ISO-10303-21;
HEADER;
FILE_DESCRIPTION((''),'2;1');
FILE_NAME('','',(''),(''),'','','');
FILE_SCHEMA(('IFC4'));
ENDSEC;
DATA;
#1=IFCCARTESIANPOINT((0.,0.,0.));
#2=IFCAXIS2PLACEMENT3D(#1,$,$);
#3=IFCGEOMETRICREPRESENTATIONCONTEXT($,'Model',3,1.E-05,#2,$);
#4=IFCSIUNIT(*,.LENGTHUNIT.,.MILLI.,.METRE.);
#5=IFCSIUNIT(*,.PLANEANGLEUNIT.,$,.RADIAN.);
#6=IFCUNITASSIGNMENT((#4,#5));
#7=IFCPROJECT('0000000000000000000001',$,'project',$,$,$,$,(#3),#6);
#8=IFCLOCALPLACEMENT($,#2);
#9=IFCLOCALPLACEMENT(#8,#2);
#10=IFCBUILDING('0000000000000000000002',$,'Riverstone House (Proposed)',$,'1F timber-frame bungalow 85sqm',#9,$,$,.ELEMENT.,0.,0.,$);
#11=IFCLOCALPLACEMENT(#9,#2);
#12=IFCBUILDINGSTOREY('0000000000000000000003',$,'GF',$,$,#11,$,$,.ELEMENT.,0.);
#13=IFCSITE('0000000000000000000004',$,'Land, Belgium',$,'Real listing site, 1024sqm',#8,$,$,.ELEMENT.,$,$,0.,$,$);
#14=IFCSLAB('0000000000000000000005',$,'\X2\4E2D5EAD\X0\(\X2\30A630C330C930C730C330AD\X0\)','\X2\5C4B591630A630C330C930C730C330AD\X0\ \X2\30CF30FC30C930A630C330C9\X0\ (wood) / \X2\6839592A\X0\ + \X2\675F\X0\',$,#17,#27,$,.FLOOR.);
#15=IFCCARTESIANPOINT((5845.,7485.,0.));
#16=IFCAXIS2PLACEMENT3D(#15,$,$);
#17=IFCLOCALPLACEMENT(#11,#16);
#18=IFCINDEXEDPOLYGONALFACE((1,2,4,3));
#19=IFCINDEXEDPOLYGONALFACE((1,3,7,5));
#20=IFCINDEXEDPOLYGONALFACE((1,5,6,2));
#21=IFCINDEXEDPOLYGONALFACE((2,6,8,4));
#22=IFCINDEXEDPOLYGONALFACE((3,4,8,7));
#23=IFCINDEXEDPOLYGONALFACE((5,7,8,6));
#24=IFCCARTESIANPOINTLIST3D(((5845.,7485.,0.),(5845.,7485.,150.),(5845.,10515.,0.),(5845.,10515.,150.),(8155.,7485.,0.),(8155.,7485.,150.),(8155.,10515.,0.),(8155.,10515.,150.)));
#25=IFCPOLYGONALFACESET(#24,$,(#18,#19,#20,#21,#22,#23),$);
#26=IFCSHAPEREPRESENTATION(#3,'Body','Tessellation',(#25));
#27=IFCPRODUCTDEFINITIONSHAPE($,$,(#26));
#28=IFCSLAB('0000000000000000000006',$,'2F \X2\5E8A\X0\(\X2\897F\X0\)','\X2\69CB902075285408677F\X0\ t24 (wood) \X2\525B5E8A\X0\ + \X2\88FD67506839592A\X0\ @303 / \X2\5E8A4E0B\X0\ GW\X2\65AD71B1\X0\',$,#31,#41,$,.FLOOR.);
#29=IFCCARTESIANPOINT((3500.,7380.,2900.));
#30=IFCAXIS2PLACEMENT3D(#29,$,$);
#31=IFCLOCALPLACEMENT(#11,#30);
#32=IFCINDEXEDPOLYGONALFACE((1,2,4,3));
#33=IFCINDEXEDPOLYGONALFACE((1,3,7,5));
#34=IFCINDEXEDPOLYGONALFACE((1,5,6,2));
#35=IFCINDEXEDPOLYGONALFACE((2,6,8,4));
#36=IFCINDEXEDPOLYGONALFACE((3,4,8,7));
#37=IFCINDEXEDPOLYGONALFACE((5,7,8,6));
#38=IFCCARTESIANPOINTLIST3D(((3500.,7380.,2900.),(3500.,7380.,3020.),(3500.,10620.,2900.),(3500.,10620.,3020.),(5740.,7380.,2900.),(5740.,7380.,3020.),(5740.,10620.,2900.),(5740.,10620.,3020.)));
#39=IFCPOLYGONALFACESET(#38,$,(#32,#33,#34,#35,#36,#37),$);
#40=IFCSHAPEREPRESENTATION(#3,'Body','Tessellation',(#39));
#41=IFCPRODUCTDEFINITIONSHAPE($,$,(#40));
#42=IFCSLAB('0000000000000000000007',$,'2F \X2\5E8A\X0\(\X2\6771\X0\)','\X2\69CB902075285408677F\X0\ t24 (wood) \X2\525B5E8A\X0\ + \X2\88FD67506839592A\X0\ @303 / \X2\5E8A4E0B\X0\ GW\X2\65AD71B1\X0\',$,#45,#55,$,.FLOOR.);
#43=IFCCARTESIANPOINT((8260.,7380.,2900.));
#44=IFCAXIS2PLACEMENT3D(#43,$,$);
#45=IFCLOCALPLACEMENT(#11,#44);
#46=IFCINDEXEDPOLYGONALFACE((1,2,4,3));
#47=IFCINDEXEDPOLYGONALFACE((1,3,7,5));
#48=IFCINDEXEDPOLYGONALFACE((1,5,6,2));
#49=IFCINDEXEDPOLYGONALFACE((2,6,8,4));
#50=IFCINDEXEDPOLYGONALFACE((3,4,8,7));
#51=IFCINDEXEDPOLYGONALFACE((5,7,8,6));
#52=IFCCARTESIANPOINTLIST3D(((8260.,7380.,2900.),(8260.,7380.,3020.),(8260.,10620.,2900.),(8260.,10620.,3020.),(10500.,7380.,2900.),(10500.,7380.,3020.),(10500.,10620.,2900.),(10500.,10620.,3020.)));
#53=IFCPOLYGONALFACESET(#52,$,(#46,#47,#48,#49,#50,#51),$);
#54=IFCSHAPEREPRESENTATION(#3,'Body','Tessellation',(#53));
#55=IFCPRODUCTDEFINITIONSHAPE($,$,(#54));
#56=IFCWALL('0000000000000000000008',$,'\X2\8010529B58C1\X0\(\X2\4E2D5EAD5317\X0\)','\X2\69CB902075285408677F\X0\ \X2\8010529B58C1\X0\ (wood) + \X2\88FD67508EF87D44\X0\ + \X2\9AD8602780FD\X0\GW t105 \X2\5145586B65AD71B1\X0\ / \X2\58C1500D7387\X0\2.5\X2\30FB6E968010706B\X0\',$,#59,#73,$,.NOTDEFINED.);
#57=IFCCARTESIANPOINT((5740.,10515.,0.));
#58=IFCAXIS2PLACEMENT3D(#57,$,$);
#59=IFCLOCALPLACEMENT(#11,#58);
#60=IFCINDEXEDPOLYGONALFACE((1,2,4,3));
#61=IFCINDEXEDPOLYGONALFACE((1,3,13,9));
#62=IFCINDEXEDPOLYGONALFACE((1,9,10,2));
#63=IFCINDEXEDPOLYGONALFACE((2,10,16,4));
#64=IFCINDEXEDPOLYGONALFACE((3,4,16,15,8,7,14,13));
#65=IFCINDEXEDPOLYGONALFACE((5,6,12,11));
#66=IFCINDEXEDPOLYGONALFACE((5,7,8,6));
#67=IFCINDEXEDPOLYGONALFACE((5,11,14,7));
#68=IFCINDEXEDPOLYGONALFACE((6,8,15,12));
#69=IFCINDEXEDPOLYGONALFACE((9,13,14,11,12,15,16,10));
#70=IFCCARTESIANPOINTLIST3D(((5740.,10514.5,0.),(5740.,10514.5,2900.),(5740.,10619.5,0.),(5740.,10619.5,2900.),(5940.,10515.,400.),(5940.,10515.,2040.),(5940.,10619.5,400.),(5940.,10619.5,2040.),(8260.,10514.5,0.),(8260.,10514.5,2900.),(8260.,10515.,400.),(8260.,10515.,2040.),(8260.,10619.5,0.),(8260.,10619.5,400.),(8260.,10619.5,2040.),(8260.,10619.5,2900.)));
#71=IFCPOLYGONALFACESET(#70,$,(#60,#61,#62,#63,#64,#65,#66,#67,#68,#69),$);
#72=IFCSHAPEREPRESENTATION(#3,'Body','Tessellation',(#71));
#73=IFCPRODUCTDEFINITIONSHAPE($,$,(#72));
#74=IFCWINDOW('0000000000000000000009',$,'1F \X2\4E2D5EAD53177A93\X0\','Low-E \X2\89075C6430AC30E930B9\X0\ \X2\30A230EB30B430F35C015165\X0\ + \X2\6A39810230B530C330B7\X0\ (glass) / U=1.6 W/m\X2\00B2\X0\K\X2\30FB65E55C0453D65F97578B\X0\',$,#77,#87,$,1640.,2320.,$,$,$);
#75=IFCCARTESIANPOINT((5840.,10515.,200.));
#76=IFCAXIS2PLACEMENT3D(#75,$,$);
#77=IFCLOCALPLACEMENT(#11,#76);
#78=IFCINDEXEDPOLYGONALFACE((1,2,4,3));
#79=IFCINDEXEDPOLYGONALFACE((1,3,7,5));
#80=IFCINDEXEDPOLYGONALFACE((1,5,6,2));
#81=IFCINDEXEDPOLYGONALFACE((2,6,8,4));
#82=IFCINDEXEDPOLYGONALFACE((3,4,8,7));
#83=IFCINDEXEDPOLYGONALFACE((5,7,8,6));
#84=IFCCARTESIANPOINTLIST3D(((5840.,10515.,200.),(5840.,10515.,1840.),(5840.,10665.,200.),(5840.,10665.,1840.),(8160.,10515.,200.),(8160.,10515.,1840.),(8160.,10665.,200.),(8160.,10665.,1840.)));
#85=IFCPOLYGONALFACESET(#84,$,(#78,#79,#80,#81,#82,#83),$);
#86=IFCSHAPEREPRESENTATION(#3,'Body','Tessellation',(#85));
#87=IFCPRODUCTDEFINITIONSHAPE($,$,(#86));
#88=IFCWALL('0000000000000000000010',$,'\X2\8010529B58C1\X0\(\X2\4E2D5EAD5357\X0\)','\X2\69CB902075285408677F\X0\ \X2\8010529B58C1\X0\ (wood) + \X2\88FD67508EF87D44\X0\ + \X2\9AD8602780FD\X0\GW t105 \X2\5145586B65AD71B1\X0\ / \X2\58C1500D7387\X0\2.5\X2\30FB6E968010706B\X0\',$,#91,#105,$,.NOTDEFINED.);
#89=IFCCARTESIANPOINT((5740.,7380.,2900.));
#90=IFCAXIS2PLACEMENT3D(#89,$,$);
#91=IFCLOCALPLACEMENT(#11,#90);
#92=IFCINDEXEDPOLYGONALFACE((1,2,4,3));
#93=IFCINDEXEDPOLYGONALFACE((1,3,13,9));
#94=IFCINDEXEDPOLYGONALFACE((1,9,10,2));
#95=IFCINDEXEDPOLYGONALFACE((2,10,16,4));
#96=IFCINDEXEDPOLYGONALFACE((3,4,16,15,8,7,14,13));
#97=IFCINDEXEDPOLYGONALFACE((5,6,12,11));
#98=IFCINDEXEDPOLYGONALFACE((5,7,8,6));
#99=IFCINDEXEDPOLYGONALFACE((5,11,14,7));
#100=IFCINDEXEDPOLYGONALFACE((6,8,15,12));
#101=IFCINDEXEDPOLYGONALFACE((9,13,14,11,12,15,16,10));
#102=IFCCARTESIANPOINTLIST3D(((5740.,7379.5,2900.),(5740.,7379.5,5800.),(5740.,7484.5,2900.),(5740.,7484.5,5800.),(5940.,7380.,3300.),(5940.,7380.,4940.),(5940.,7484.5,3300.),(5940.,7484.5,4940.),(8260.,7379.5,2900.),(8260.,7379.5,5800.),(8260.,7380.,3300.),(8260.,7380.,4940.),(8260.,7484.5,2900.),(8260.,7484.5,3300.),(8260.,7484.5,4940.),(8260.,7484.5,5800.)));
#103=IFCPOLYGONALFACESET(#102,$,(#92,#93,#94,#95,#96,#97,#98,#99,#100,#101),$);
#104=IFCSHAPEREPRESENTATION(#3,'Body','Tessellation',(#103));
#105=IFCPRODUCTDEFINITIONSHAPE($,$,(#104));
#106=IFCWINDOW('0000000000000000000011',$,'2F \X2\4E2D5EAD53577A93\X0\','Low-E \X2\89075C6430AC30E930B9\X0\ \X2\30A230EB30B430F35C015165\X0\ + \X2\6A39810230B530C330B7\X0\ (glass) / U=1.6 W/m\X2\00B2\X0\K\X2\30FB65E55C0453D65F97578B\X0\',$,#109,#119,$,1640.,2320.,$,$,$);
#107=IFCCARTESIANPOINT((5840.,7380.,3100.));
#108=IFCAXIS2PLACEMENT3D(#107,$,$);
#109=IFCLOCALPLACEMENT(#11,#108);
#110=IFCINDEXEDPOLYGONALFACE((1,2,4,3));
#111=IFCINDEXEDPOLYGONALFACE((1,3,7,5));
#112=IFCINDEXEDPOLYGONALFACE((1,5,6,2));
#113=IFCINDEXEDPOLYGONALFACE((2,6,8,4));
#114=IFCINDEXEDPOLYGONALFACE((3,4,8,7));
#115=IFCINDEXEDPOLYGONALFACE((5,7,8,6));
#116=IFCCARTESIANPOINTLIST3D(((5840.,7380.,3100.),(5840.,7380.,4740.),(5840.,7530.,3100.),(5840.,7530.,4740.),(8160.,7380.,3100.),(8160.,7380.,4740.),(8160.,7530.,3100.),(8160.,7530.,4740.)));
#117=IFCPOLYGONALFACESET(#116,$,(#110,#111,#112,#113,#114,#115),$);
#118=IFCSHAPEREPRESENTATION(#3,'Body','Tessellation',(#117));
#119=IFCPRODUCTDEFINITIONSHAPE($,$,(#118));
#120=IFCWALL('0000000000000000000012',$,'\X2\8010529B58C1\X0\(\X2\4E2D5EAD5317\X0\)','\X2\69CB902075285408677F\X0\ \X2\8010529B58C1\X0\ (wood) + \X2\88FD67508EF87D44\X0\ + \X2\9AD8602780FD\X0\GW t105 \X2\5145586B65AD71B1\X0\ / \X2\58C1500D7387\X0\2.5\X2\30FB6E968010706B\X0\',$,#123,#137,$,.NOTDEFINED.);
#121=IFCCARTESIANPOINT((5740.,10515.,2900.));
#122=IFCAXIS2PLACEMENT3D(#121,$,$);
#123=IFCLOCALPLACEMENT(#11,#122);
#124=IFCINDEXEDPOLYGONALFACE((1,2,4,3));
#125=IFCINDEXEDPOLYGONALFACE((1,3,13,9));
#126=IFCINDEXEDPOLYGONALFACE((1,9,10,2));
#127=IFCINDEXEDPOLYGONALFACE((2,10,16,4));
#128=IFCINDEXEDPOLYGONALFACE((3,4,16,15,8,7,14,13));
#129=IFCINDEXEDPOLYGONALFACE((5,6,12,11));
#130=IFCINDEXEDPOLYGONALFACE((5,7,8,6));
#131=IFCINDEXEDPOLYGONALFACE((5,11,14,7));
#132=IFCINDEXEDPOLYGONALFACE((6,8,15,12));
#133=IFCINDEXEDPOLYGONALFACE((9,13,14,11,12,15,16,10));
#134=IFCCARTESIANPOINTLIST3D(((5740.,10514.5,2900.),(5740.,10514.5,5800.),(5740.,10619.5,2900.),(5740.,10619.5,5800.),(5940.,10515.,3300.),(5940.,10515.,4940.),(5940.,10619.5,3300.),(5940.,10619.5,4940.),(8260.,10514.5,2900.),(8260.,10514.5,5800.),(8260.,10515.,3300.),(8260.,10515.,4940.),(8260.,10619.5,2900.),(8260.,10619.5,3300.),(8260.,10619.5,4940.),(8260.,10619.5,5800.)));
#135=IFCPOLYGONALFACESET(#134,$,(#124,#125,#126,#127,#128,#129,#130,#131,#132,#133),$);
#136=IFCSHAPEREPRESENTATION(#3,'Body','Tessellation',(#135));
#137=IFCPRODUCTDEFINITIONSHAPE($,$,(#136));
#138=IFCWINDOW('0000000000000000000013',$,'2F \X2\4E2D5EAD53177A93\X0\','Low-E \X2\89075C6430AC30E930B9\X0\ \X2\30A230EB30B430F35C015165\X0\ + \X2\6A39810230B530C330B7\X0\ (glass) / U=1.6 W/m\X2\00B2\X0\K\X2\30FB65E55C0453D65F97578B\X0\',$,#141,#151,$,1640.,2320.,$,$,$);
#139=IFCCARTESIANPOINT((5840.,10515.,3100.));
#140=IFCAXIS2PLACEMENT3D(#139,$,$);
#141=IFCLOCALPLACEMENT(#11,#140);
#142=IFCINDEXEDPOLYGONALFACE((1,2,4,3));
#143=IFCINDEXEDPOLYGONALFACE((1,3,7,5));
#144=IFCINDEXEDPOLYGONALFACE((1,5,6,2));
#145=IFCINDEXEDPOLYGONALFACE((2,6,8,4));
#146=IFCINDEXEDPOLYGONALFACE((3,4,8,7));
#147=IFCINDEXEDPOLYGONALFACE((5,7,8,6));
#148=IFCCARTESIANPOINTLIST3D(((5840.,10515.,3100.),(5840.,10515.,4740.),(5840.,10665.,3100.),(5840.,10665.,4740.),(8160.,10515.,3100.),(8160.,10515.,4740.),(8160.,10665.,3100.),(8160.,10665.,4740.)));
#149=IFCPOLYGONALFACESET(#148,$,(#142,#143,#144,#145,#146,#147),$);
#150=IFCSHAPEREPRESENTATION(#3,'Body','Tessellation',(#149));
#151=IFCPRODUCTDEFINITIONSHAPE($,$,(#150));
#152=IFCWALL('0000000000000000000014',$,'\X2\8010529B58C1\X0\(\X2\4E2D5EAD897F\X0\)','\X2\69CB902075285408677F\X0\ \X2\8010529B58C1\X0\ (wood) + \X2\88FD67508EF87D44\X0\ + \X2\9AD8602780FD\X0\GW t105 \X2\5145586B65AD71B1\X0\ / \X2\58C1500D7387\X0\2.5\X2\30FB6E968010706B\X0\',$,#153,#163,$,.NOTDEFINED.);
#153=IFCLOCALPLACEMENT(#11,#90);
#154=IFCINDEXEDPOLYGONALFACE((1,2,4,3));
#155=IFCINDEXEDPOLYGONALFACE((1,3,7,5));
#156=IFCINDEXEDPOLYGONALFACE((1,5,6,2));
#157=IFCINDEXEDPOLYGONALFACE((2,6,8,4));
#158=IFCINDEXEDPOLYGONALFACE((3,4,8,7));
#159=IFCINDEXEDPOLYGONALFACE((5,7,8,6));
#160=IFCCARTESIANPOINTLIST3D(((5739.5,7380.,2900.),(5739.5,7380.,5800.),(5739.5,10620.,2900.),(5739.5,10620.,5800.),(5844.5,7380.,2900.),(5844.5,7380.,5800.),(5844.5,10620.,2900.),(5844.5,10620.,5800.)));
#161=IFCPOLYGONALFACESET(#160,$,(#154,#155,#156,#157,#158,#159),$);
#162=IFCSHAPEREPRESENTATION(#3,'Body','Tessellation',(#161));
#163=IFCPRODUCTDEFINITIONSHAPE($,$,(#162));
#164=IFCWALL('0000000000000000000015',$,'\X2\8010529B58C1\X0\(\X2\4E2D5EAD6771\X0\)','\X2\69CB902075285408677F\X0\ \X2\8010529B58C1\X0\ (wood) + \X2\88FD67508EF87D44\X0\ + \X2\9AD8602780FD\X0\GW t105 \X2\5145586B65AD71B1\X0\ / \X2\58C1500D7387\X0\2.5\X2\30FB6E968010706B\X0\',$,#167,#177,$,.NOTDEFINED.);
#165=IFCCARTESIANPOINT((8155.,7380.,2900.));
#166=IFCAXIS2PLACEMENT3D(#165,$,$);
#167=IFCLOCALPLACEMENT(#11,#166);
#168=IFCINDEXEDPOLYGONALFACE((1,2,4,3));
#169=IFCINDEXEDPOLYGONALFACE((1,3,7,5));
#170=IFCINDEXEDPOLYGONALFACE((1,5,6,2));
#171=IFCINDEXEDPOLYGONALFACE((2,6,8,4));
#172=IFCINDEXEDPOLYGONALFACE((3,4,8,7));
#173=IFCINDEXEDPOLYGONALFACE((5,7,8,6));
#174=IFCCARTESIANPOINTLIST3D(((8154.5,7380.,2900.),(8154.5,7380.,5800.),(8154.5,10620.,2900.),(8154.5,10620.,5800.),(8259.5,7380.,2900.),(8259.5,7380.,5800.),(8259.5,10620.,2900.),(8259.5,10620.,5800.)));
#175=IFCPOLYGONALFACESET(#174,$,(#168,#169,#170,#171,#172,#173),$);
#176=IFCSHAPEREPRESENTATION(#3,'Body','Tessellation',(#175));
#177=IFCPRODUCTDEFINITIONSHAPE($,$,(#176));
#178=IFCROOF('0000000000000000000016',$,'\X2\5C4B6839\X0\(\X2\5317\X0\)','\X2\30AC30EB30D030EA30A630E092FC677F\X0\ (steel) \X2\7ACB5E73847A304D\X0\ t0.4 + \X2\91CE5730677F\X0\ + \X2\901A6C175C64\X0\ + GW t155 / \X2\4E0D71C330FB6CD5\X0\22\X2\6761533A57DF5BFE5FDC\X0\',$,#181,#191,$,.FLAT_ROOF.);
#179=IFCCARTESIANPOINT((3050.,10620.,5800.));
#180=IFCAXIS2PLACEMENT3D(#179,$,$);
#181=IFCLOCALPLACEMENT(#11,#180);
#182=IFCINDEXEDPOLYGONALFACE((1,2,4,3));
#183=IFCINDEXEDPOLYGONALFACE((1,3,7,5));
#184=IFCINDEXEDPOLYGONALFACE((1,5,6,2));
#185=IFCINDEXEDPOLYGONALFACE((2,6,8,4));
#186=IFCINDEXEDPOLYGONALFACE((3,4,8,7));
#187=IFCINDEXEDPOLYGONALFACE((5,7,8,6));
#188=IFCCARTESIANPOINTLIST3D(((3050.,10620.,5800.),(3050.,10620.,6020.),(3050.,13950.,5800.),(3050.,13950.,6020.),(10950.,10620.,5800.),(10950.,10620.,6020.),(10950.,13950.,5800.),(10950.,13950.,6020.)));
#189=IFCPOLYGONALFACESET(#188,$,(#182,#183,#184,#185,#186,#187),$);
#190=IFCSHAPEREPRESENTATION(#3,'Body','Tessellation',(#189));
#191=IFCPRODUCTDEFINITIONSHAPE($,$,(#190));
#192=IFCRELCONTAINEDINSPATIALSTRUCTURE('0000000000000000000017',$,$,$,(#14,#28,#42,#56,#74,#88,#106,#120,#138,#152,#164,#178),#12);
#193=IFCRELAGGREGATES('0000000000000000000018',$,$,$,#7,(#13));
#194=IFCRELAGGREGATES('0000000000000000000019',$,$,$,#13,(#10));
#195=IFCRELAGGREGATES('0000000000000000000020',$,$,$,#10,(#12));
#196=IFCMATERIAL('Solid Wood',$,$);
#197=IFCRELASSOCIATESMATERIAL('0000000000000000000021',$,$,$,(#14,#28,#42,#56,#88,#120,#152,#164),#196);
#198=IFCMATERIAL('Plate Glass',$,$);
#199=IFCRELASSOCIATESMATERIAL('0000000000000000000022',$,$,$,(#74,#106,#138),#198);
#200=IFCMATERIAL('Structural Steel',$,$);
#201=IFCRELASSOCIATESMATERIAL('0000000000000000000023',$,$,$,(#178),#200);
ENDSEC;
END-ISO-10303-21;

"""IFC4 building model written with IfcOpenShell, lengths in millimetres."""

from ifc_helpers import new_model, si_unit, frame, frame_2d, origin, place, context, project, spatial, rectangle, extrude, material, element, fill, save


model = new_model("IFC4")

# Units and contexts
model_context = context("Model", 3, precision=1e-05, world=origin())
ifc_project = project(units=[si_unit("LENGTHUNIT", "METRE", prefix="MILLI"), si_unit("PLANEANGLEUNIT", "RADIAN")], contexts=[model_context])

# Site, building, storey
site_placement = place(None, origin())
site = spatial("IfcSite", under=ifc_project, at=site_placement, Name="Land, Belgium", ObjectType="Real listing site, 1024sqm", CompositionType="ELEMENT", RefElevation=0.0)
building_placement = place(site_placement, origin())
building = spatial("IfcBuilding", under=site, at=building_placement, Name="Riverstone House (Proposed)", ObjectType="1F timber-frame bungalow 85sqm", CompositionType="ELEMENT", ElevationOfRefHeight=0.0, ElevationOfTerrain=0.0)
storey_placement = place(building_placement, origin())
storey = spatial("IfcBuildingStorey", under=building, at=storey_placement, Name="GF", CompositionType="ELEMENT", Elevation=0.0)

# Slabs
ifc_material_1 = material(Name="Solid Wood")
slab_1_placement = place(storey_placement, frame((5845.0, 7485.0, 0.0)))
element("IfcSlab", 1, at=slab_1_placement, inside=storey, material=ifc_material_1, Name="中庭(ウッドデッキ)", Description="屋外ウッドデッキ ハードウッド (wood) / 根太 + 束", PredefinedType="FLOOR", context=model_context, shape_type="SweptSolid", body=[
    extrude(rectangle(XDim=2310.0, YDim=3030.0, at=frame_2d((1155.0, 1515.0))), frame((5845.0, 7485.0, 0.0)), (0.0, 0.0, 1.0), 150.0),
])
slab_2_placement = place(storey_placement, frame((3500.0, 7380.0, 2900.0)))
element("IfcSlab", 2, at=slab_2_placement, inside=storey, material=ifc_material_1, Name="2F 床(西)", Description="構造用合板 t24 (wood) 剛床 + 製材根太 @303 / 床下 GW断熱", PredefinedType="FLOOR", context=model_context, shape_type="SweptSolid", body=[
    extrude(rectangle(XDim=2240.0, YDim=3240.0, at=frame_2d((1120.0, 1620.0))), frame((3500.0, 7380.0, 2900.0)), (0.0, 0.0, 1.0), 120.0),
])
slab_3_placement = place(storey_placement, frame((8260.0, 7380.0, 2900.0)))
element("IfcSlab", 3, at=slab_3_placement, inside=storey, material=ifc_material_1, Name="2F 床(東)", Description="構造用合板 t24 (wood) 剛床 + 製材根太 @303 / 床下 GW断熱", PredefinedType="FLOOR", context=model_context, shape_type="SweptSolid", body=[
    extrude(rectangle(XDim=2240.0, YDim=3240.0, at=frame_2d((1120.0, 1620.0))), frame((8260.0, 7380.0, 2900.0)), (0.0, 0.0, 1.0), 120.0),
])

# Walls, openings, windows
wall_1_placement = place(storey_placement, frame((5740.0, 10515.0, 0.0)))
wall_1 = element("IfcWall", 4, at=wall_1_placement, inside=storey, material=ifc_material_1, Name="耐力壁(中庭北)", Description="構造用合板 耐力壁 (wood) + 製材軸組 + 高性能GW t105 充填断熱 / 壁倍率2.5・準耐火", PredefinedType="NOTDEFINED", context=model_context, shape_type="SweptSolid", body=[
    extrude(rectangle(XDim=2520.0, YDim=105.0, at=frame_2d((1260.0, 52.0))), frame((5740.0, 10515.0, 0.0)), (0.0, 0.0, 1.0), 2900.0),
])
opening_1_placement = place(storey_placement, frame((5840.0, 10515.0, 200.0)))
opening_1 = element("IfcOpeningElement", 5, at=opening_1_placement, cuts=wall_1, PredefinedType="NOTDEFINED", context=model_context, shape_type="SweptSolid", body=[
    extrude(rectangle(XDim=2320.0, YDim=150.0, at=frame_2d((1160.0, 75.0))), frame((5840.0, 10515.0, 200.0)), (0.0, 0.0, 1.0), 1640.0),
])
ifc_material_2 = material(Name="Plate Glass")
window_1_placement = place(storey_placement, frame((5840.0, 10515.0, 200.0)))
window_1 = element("IfcWindow", 6, at=window_1_placement, inside=storey, material=ifc_material_2, Name="1F 中庭北窓", Description="Low-E 複層ガラス アルゴン封入 + 樹脂サッシ (glass) / U=1.6 W/m²K・日射取得型", OverallHeight=1640.0, OverallWidth=2320.0, context=model_context, shape_type="SweptSolid", body=[
    extrude(rectangle(XDim=2320.0, YDim=150.0, at=frame_2d((1160.0, 75.0))), frame((5840.0, 10515.0, 200.0)), (0.0, 0.0, 1.0), 1640.0),
])
fill(opening_1, window_1)
wall_2_placement = place(storey_placement, frame((5740.0, 7380.0, 2900.0)))
wall_2 = element("IfcWall", 7, at=wall_2_placement, inside=storey, material=ifc_material_1, Name="耐力壁(中庭南)", Description="構造用合板 耐力壁 (wood) + 製材軸組 + 高性能GW t105 充填断熱 / 壁倍率2.5・準耐火", PredefinedType="NOTDEFINED", context=model_context, shape_type="SweptSolid", body=[
    extrude(rectangle(XDim=2520.0, YDim=105.0, at=frame_2d((1260.0, 52.0))), frame((5740.0, 7380.0, 2900.0)), (0.0, 0.0, 1.0), 2900.0),
])
opening_2_placement = place(storey_placement, frame((5840.0, 7380.0, 3100.0)))
opening_2 = element("IfcOpeningElement", 8, at=opening_2_placement, cuts=wall_2, PredefinedType="NOTDEFINED", context=model_context, shape_type="SweptSolid", body=[
    extrude(rectangle(XDim=2320.0, YDim=150.0, at=frame_2d((1160.0, 75.0))), frame((5840.0, 7380.0, 3100.0)), (0.0, 0.0, 1.0), 1640.0),
])
window_2_placement = place(storey_placement, frame((5840.0, 7380.0, 3100.0)))
window_2 = element("IfcWindow", 9, at=window_2_placement, inside=storey, material=ifc_material_2, Name="2F 中庭南窓", Description="Low-E 複層ガラス アルゴン封入 + 樹脂サッシ (glass) / U=1.6 W/m²K・日射取得型", OverallHeight=1640.0, OverallWidth=2320.0, context=model_context, shape_type="SweptSolid", body=[
    extrude(rectangle(XDim=2320.0, YDim=150.0, at=frame_2d((1160.0, 75.0))), frame((5840.0, 7380.0, 3100.0)), (0.0, 0.0, 1.0), 1640.0),
])
fill(opening_2, window_2)
wall_3_placement = place(storey_placement, frame((5740.0, 10515.0, 2900.0)))
wall_3 = element("IfcWall", 10, at=wall_3_placement, inside=storey, material=ifc_material_1, Name="耐力壁(中庭北)", Description="構造用合板 耐力壁 (wood) + 製材軸組 + 高性能GW t105 充填断熱 / 壁倍率2.5・準耐火", PredefinedType="NOTDEFINED", context=model_context, shape_type="SweptSolid", body=[
    extrude(rectangle(XDim=2520.0, YDim=105.0, at=frame_2d((1260.0, 52.0))), frame((5740.0, 10515.0, 2900.0)), (0.0, 0.0, 1.0), 2900.0),
])
opening_3_placement = place(storey_placement, frame((5840.0, 10515.0, 3100.0)))
opening_3 = element("IfcOpeningElement", 11, at=opening_3_placement, cuts=wall_3, PredefinedType="NOTDEFINED", context=model_context, shape_type="SweptSolid", body=[
    extrude(rectangle(XDim=2320.0, YDim=150.0, at=frame_2d((1160.0, 75.0))), frame((5840.0, 10515.0, 3100.0)), (0.0, 0.0, 1.0), 1640.0),
])
window_3_placement = place(storey_placement, frame((5840.0, 10515.0, 3100.0)))
window_3 = element("IfcWindow", 12, at=window_3_placement, inside=storey, material=ifc_material_2, Name="2F 中庭北窓", Description="Low-E 複層ガラス アルゴン封入 + 樹脂サッシ (glass) / U=1.6 W/m²K・日射取得型", OverallHeight=1640.0, OverallWidth=2320.0, context=model_context, shape_type="SweptSolid", body=[
    extrude(rectangle(XDim=2320.0, YDim=150.0, at=frame_2d((1160.0, 75.0))), frame((5840.0, 10515.0, 3100.0)), (0.0, 0.0, 1.0), 1640.0),
])
fill(opening_3, window_3)

# Walls
wall_4_placement = place(storey_placement, frame((5740.0, 7380.0, 2900.0)))
element("IfcWall", 13, at=wall_4_placement, inside=storey, material=ifc_material_1, Name="耐力壁(中庭西)", Description="構造用合板 耐力壁 (wood) + 製材軸組 + 高性能GW t105 充填断熱 / 壁倍率2.5・準耐火", PredefinedType="NOTDEFINED", context=model_context, shape_type="SweptSolid", body=[
    extrude(rectangle(XDim=105.0, YDim=3240.0, at=frame_2d((52.0, 1620.0))), frame((5740.0, 7380.0, 2900.0)), (0.0, 0.0, 1.0), 2900.0),
])
wall_5_placement = place(storey_placement, frame((8155.0, 7380.0, 2900.0)))
element("IfcWall", 14, at=wall_5_placement, inside=storey, material=ifc_material_1, Name="耐力壁(中庭東)", Description="構造用合板 耐力壁 (wood) + 製材軸組 + 高性能GW t105 充填断熱 / 壁倍率2.5・準耐火", PredefinedType="NOTDEFINED", context=model_context, shape_type="SweptSolid", body=[
    extrude(rectangle(XDim=105.0, YDim=3240.0, at=frame_2d((52.0, 1620.0))), frame((8155.0, 7380.0, 2900.0)), (0.0, 0.0, 1.0), 2900.0),
])

# Roof
ifc_material_3 = material(Name="Structural Steel")
roof_1_placement = place(storey_placement, frame((3050.0, 10620.0, 5800.0)))
element("IfcRoof", 15, at=roof_1_placement, inside=storey, material=ifc_material_3, Name="屋根(北)", Description="ガルバリウム鋼板 (steel) 立平葺き t0.4 + 野地板 + 通気層 + GW t155 / 不燃・法22条区域対応", PredefinedType="FLAT_ROOF", context=model_context, shape_type="SweptSolid", body=[
    extrude(rectangle(XDim=7900.0, YDim=3330.0, at=frame_2d((3950.0, 1665.0))), frame((3050.0, 10620.0, 5800.0)), (0.0, 0.0, 1.0), 220.0),
])

save(model, "model.ifc")
